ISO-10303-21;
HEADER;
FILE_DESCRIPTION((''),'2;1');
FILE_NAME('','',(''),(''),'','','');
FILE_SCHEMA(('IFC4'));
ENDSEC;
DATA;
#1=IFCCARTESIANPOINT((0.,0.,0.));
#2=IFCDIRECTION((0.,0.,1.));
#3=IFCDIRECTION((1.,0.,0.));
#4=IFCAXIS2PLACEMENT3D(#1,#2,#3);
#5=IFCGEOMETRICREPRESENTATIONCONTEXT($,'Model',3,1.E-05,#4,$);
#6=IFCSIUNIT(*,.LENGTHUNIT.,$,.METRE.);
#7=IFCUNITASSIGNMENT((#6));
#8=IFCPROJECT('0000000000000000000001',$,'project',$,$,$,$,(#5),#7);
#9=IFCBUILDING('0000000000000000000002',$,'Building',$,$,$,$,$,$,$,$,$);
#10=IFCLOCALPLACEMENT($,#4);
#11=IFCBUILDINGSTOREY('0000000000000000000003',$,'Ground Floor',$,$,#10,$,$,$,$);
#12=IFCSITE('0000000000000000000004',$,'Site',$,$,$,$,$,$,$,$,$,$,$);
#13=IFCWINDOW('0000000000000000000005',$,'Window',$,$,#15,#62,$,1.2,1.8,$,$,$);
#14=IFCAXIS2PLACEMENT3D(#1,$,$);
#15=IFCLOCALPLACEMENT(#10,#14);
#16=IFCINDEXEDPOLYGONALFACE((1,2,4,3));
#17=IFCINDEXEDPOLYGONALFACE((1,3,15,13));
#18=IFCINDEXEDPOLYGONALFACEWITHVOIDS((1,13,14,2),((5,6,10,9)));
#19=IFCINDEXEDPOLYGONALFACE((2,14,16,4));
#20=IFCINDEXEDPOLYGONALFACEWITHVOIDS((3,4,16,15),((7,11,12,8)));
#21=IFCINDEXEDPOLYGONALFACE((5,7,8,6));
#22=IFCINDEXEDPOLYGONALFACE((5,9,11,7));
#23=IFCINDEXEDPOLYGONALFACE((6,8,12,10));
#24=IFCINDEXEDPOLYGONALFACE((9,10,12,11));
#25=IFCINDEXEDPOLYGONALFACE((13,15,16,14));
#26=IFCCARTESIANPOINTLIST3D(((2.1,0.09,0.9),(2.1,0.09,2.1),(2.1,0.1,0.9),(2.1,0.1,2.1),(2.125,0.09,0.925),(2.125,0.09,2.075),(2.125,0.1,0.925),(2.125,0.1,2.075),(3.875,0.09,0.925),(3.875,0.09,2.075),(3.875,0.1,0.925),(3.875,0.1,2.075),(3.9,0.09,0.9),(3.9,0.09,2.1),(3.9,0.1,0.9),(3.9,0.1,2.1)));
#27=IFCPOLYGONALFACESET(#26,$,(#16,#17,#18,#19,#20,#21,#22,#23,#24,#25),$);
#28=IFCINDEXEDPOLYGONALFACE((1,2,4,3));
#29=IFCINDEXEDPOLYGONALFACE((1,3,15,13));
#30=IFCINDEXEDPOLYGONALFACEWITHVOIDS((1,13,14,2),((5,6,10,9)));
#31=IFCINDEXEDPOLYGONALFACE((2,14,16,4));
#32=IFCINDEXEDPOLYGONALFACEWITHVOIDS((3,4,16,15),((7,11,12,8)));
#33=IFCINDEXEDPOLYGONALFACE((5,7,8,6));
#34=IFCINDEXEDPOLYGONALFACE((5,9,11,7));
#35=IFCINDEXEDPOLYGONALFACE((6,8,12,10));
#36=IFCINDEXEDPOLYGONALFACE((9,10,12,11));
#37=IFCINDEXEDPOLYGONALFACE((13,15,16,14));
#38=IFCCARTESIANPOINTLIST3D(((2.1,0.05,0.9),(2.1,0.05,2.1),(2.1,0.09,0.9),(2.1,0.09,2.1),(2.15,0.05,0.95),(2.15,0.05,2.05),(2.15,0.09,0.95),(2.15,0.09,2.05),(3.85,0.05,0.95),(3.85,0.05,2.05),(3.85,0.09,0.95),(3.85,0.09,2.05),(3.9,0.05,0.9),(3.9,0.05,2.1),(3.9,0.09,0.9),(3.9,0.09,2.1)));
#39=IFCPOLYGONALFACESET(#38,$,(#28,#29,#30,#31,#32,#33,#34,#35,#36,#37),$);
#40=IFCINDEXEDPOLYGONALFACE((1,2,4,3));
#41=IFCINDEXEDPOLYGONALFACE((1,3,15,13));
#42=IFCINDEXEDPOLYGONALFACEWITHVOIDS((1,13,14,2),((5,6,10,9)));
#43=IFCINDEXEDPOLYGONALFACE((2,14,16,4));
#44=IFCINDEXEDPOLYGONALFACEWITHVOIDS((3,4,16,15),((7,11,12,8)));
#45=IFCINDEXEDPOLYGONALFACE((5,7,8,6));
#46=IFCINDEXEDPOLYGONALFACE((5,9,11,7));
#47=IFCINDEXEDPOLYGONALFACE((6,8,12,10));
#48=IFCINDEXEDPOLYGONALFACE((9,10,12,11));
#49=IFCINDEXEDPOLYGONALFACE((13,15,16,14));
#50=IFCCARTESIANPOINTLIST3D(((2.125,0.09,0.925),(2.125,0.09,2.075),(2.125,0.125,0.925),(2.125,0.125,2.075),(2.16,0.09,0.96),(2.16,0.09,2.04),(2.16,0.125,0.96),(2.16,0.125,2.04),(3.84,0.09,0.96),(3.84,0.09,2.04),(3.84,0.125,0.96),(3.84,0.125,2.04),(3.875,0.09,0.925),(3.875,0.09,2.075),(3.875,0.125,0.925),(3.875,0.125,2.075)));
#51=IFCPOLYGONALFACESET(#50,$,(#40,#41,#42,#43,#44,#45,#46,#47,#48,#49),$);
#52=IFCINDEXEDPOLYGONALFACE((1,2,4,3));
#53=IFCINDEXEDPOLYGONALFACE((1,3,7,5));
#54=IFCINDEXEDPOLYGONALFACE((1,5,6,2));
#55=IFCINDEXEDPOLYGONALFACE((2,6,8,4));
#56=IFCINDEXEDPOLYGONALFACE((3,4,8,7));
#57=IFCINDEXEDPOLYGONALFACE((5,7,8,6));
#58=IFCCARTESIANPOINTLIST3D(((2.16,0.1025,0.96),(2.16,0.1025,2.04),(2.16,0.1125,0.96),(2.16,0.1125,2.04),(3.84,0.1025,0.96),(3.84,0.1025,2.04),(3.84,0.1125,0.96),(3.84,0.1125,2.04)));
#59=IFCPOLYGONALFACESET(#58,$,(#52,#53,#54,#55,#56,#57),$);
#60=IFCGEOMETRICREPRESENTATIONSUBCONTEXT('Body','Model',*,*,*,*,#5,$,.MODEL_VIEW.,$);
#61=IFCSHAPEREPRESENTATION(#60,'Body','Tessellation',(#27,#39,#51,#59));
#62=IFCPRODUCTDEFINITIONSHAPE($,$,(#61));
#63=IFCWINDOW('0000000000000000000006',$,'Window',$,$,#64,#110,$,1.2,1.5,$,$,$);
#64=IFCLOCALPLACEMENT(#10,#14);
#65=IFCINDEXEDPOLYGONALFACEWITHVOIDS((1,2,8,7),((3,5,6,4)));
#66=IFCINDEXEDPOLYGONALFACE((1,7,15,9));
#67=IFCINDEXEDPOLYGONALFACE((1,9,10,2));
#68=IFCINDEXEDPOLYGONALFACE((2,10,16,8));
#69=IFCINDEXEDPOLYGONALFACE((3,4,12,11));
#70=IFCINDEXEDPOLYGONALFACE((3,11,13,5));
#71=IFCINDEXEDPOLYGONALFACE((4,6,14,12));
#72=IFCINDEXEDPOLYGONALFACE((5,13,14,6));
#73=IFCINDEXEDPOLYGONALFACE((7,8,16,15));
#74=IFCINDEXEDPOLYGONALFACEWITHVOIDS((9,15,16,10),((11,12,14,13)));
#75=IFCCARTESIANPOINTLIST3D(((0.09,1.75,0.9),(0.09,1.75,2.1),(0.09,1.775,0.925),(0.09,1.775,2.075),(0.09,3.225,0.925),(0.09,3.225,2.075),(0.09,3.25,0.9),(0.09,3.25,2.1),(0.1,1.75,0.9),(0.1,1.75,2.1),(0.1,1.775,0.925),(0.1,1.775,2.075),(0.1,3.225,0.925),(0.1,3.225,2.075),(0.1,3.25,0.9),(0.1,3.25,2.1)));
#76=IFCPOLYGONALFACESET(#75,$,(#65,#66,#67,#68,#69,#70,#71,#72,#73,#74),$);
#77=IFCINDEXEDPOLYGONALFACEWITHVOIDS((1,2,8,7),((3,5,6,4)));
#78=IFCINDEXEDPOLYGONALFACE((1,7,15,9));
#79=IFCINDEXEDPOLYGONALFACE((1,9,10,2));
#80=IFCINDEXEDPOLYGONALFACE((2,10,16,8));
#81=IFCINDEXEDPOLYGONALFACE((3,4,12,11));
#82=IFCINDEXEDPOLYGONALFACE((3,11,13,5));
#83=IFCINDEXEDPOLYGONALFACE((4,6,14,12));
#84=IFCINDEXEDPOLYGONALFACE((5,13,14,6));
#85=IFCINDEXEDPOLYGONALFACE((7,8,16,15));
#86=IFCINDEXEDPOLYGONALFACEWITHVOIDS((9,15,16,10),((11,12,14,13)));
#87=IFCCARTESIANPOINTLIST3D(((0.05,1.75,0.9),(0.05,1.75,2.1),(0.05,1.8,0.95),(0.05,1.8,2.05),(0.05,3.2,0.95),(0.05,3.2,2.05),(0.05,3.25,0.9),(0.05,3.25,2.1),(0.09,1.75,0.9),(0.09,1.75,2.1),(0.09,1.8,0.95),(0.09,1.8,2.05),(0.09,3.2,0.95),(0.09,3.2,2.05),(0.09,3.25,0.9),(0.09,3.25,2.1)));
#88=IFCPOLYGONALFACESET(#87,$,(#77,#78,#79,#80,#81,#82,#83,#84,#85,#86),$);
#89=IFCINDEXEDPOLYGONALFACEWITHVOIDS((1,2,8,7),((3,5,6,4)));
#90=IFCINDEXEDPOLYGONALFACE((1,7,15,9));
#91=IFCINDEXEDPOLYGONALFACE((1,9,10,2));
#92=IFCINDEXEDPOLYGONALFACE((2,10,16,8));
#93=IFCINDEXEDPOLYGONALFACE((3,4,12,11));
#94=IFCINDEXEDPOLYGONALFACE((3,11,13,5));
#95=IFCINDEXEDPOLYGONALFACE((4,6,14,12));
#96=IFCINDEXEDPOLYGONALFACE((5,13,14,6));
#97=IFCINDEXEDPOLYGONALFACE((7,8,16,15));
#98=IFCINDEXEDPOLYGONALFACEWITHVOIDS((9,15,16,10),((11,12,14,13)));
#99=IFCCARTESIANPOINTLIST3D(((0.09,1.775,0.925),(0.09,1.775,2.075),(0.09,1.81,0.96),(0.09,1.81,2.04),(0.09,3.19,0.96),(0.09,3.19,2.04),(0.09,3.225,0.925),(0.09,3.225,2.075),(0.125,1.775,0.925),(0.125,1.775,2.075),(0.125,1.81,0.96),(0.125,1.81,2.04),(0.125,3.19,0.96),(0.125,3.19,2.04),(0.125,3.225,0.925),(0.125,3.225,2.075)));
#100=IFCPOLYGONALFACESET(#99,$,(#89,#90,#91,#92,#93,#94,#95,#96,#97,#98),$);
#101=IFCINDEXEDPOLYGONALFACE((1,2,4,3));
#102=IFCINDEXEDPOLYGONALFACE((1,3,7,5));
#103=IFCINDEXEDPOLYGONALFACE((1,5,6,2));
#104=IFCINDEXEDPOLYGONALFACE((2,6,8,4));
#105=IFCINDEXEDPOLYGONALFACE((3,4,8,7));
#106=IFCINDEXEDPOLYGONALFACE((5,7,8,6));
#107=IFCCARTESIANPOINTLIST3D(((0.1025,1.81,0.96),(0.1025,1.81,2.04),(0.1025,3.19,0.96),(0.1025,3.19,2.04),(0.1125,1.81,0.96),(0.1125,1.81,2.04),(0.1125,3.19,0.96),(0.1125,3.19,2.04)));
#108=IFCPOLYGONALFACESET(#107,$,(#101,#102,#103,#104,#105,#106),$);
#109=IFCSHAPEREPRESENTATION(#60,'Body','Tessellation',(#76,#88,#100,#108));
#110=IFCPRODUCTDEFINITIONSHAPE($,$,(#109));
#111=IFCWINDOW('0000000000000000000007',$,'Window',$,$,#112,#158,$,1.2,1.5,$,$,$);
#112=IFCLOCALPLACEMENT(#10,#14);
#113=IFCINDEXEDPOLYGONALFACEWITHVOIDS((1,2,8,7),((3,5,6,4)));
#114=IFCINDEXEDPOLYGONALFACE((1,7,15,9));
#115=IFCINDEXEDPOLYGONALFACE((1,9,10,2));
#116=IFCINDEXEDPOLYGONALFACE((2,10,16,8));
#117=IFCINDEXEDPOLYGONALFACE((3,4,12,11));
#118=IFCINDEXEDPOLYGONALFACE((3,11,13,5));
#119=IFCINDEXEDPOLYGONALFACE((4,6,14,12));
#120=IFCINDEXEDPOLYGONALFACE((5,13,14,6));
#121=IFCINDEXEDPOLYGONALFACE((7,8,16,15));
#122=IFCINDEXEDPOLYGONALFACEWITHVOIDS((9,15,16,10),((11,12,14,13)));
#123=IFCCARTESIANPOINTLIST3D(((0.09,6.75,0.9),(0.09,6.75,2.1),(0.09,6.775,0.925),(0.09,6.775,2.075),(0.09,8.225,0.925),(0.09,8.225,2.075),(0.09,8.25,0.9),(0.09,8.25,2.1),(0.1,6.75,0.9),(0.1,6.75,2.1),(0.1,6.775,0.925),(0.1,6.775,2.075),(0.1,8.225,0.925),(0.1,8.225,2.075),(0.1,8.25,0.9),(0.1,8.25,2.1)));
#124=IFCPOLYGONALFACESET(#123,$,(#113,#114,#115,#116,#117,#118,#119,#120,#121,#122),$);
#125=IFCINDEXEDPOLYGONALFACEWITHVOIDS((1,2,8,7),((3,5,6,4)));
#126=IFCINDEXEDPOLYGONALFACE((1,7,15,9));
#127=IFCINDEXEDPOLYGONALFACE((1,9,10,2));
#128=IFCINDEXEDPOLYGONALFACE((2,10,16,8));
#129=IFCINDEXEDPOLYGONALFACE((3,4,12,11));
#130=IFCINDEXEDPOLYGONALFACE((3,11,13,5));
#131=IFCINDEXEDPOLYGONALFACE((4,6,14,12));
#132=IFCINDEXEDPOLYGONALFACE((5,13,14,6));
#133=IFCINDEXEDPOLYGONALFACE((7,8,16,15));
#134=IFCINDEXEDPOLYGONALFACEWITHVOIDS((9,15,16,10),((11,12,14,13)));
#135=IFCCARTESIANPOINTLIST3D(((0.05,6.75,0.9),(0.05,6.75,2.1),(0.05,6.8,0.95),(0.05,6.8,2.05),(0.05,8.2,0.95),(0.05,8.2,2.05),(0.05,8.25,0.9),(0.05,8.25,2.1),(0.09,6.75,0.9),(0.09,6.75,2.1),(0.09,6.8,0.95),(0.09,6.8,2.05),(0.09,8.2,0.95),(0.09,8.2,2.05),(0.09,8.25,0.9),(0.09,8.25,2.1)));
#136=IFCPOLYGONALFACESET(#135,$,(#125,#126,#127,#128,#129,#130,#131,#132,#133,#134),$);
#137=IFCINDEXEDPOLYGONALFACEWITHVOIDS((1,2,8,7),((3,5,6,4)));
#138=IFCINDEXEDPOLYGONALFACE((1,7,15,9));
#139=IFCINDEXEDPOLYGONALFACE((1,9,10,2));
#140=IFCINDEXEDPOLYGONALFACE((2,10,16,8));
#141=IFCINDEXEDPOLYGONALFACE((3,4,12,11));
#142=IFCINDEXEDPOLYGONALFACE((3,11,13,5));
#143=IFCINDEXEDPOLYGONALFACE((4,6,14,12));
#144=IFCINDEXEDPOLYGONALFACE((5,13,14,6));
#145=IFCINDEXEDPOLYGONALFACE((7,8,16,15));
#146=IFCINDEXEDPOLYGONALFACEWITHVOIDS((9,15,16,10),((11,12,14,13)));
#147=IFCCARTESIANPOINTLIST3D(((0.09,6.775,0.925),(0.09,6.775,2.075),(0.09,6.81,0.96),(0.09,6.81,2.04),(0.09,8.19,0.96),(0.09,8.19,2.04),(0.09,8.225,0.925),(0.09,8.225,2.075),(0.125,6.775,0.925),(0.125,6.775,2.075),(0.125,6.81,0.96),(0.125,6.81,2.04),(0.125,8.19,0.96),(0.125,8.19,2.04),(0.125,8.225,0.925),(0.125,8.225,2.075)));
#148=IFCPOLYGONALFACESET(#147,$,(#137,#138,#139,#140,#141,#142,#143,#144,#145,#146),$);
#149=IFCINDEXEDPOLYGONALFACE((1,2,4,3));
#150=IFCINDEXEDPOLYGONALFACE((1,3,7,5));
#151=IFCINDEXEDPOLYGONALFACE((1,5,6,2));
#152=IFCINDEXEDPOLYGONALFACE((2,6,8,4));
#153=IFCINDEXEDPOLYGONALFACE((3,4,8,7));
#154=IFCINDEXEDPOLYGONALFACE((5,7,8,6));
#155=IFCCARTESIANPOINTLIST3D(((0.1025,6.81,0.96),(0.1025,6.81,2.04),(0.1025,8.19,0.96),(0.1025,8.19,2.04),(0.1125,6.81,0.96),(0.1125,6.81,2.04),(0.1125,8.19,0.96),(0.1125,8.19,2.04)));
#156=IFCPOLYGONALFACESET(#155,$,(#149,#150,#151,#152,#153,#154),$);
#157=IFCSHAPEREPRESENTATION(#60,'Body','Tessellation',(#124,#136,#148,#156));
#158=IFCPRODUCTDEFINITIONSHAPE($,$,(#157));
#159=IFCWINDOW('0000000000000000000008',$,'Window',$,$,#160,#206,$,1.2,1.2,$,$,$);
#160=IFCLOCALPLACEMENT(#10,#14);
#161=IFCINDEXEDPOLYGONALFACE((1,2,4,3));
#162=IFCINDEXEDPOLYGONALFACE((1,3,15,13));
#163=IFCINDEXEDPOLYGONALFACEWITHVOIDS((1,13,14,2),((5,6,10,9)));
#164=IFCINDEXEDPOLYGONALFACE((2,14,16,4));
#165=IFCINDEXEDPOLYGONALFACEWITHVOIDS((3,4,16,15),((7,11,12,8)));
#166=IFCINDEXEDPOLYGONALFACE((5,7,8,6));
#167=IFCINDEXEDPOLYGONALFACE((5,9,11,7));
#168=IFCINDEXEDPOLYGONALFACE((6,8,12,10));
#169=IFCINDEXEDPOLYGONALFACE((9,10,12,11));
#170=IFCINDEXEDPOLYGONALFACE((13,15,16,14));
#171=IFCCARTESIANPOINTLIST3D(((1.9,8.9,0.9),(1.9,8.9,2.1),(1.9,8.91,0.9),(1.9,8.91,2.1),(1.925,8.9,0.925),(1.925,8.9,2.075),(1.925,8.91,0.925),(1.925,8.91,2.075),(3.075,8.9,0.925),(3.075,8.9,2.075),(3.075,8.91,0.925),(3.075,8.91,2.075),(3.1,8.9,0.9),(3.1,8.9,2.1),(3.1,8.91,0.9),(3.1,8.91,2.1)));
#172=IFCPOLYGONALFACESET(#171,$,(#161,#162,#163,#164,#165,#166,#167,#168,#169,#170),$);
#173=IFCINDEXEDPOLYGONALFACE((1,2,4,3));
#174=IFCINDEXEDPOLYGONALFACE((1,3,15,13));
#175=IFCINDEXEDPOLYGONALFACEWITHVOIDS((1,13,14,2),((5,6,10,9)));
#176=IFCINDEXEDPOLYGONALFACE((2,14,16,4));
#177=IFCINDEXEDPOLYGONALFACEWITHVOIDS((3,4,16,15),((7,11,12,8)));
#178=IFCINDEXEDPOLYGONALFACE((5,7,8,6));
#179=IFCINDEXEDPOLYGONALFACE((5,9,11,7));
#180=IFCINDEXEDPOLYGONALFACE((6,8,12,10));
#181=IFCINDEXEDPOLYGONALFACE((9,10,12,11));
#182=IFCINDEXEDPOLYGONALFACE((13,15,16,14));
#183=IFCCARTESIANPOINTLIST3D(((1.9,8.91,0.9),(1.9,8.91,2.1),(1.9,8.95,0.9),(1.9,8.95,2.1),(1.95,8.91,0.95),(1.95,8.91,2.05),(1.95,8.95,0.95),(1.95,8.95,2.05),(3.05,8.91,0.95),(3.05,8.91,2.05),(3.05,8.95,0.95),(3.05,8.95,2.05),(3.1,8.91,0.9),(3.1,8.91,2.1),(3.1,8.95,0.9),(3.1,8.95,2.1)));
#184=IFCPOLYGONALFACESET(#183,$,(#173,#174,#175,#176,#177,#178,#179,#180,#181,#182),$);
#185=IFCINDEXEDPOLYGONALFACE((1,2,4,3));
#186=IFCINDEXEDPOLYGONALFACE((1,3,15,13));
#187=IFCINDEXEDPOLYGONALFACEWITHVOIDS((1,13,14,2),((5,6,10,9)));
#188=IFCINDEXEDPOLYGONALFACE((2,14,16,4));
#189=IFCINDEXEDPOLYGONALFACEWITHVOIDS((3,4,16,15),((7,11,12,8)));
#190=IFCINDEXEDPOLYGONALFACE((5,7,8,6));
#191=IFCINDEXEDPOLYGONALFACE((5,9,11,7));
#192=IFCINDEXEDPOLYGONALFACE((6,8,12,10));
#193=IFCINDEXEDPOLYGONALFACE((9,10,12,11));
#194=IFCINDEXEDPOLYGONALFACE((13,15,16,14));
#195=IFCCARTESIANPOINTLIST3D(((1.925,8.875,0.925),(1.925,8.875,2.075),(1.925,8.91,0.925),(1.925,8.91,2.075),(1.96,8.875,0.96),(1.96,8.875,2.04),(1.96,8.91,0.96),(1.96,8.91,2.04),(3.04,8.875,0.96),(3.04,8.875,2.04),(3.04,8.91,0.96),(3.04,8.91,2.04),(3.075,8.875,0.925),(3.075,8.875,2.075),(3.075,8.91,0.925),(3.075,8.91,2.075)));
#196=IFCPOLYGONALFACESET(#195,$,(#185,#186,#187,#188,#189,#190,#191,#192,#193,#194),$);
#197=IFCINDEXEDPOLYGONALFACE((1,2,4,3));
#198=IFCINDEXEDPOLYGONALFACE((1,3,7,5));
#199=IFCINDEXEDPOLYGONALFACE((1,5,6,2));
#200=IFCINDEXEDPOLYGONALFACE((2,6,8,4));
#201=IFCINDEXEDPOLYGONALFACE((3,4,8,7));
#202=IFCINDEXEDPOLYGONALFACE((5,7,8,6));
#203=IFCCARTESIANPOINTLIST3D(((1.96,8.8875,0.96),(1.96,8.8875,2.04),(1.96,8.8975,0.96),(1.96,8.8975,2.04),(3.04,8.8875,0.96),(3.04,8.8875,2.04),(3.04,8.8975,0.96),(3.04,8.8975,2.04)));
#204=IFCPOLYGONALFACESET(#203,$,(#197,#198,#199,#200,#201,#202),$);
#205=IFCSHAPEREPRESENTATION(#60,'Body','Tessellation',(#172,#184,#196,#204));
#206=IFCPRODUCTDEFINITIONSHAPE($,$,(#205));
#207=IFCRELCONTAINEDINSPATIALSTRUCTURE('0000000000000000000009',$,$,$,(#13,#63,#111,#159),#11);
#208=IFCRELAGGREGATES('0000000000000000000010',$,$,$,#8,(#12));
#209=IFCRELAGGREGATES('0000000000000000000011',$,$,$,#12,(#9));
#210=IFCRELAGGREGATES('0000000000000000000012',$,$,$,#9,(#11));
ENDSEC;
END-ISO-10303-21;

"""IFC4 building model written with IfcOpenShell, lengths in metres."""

from ifc_helpers import new_model, si_unit, frame, origin_with_axes, place, context, subcontext, project, spatial, line, indexed_curve, outline, extrude, element, save


model = new_model("IFC4")

# Units and contexts
model_context = context("Model", 3, precision=1e-05, world=origin_with_axes())
body_context = subcontext(model_context, "Body", "Model", "MODEL_VIEW")
ifc_project = project(units=[si_unit("LENGTHUNIT", "METRE")], contexts=[model_context])

# Site, building, storey
site = spatial("IfcSite", under=ifc_project, Name="Site")
building = spatial("IfcBuilding", under=site, Name="Building")
storey_placement = place(None, origin_with_axes())
storey = spatial("IfcBuildingStorey", under=building, at=storey_placement, Name="Ground Floor")

# Windows
window_1_placement = place(storey_placement, frame((2.1, 0.0, 0.9), z_axis=(0.0, 0.0, 1.0), x_axis=(1.0, 0.0, 0.0)))
element("IfcWindow", 1, at=window_1_placement, inside=storey, Name="Window", OverallHeight=1.2, OverallWidth=1.8, context=body_context, shape_type="SweptSolid", body=[
    extrude(outline(indexed_curve([(0.0, 0.0), (1.8, 0.0), (1.8, 1.2), (0.0, 1.2)], segments=[line(1, 2, 3, 4, 1)]), holes=[indexed_curve([(0.025, 0.025), (1.775, 0.025), (1.775, 1.175), (0.025, 1.175)], segments=[line(1, 2, 3, 4, 1)])]), frame((0.0, 0.09, 0.0), z_axis=(0.0, -1.0, 0.0), x_axis=(1.0, 0.0, 0.0)), (0.0, 0.0, -1.0), 0.01),
    extrude(outline(indexed_curve([(0.0, 0.0), (1.8, 0.0), (1.8, 1.2), (0.0, 1.2)], segments=[line(1, 2, 3, 4, 1)]), holes=[indexed_curve([(0.05, 0.05), (1.75, 0.05), (1.75, 1.15), (0.05, 1.15)], segments=[line(1, 2, 3, 4, 1)])]), frame((0.0, 0.05, 0.0), z_axis=(0.0, -1.0, 0.0), x_axis=(1.0, 0.0, 0.0)), (0.0, 0.0, -1.0), 0.04),
    extrude(outline(indexed_curve([(0.0, 0.0), (1.75, 0.0), (1.75, 1.15), (0.0, 1.15)], segments=[line(1, 2, 3, 4, 1)]), holes=[indexed_curve([(0.035, 0.035), (1.715, 0.035), (1.715, 1.115), (0.035, 1.115)], segments=[line(1, 2, 3, 4, 1)])]), frame((0.025, 0.09, 0.025), z_axis=(0.0, -1.0, 0.0), x_axis=(1.0, 0.0, 0.0)), (0.0, 0.0, -1.0), 0.035),
    extrude(outline(indexed_curve([(0.035, 0.035), (1.715, 0.035), (1.715, 1.115), (0.035, 1.115)], segments=[line(1, 2, 3, 4, 1)])), frame((0.025, 0.1025, 0.025), z_axis=(0.0, -1.0, 0.0), x_axis=(1.0, 0.0, 0.0)), (0.0, 0.0, -1.0), 0.01),
])
for number, where, z_axis, x_axis, name in (
    (2, (0.0, 3.25, 0.9), (0.0, 0.0, 1.0), (0.0, -1.0, 0.0), "Window"),
    (3, (0.0, 8.25, 0.9), (0.0, 0.0, 1.0), (0.0, -1.0, 0.0), "Window"),
):
    element("IfcWindow", number, at=place(storey_placement, frame(where, z_axis=z_axis, x_axis=x_axis)), inside=storey, Name=name, OverallHeight=1.2, OverallWidth=1.5, context=body_context, shape_type="SweptSolid", body=[
        extrude(outline(indexed_curve([(0.0, 0.0), (1.5, 0.0), (1.5, 1.2), (0.0, 1.2)], segments=[line(1, 2, 3, 4, 1)]), holes=[indexed_curve([(0.025, 0.025), (1.475, 0.025), (1.475, 1.175), (0.025, 1.175)], segments=[line(1, 2, 3, 4, 1)])]), frame((0.0, 0.09, 0.0), z_axis=(0.0, -1.0, 0.0), x_axis=(1.0, 0.0, 0.0)), (0.0, 0.0, -1.0), 0.01),
        extrude(outline(indexed_curve([(0.0, 0.0), (1.5, 0.0), (1.5, 1.2), (0.0, 1.2)], segments=[line(1, 2, 3, 4, 1)]), holes=[indexed_curve([(0.05, 0.05), (1.45, 0.05), (1.45, 1.15), (0.05, 1.15)], segments=[line(1, 2, 3, 4, 1)])]), frame((0.0, 0.05, 0.0), z_axis=(0.0, -1.0, 0.0), x_axis=(1.0, 0.0, 0.0)), (0.0, 0.0, -1.0), 0.04),
        extrude(outline(indexed_curve([(0.0, 0.0), (1.45, 0.0), (1.45, 1.15), (0.0, 1.15)], segments=[line(1, 2, 3, 4, 1)]), holes=[indexed_curve([(0.035, 0.035), (1.415, 0.035), (1.415, 1.115), (0.035, 1.115)], segments=[line(1, 2, 3, 4, 1)])]), frame((0.025, 0.09, 0.025), z_axis=(0.0, -1.0, 0.0), x_axis=(1.0, 0.0, 0.0)), (0.0, 0.0, -1.0), 0.035),
        extrude(outline(indexed_curve([(0.035, 0.035), (1.415, 0.035), (1.415, 1.115), (0.035, 1.115)], segments=[line(1, 2, 3, 4, 1)])), frame((0.025, 0.1025, 0.025), z_axis=(0.0, -1.0, 0.0), x_axis=(1.0, 0.0, 0.0)), (0.0, 0.0, -1.0), 0.01),
    ])
window_2_placement = place(storey_placement, frame((3.1, 9.0, 0.9), z_axis=(0.0, 0.0, 1.0), x_axis=(-1.0, 0.0, 0.0)))
element("IfcWindow", 4, at=window_2_placement, inside=storey, Name="Window", OverallHeight=1.2, OverallWidth=1.2, context=body_context, shape_type="SweptSolid", body=[
    extrude(outline(indexed_curve([(0.0, 0.0), (1.2, 0.0), (1.2, 1.2), (0.0, 1.2)], segments=[line(1, 2, 3, 4, 1)]), holes=[indexed_curve([(0.025, 0.025), (1.175, 0.025), (1.175, 1.175), (0.025, 1.175)], segments=[line(1, 2, 3, 4, 1)])]), frame((0.0, 0.09, 0.0), z_axis=(0.0, -1.0, 0.0), x_axis=(1.0, 0.0, 0.0)), (0.0, 0.0, -1.0), 0.01),
    extrude(outline(indexed_curve([(0.0, 0.0), (1.2, 0.0), (1.2, 1.2), (0.0, 1.2)], segments=[line(1, 2, 3, 4, 1)]), holes=[indexed_curve([(0.05, 0.05), (1.15, 0.05), (1.15, 1.15), (0.05, 1.15)], segments=[line(1, 2, 3, 4, 1)])]), frame((0.0, 0.05, 0.0), z_axis=(0.0, -1.0, 0.0), x_axis=(1.0, 0.0, 0.0)), (0.0, 0.0, -1.0), 0.04),
    extrude(outline(indexed_curve([(0.0, 0.0), (1.15, 0.0), (1.15, 1.15), (0.0, 1.15)], segments=[line(1, 2, 3, 4, 1)]), holes=[indexed_curve([(0.035, 0.035), (1.115, 0.035), (1.115, 1.115), (0.035, 1.115)], segments=[line(1, 2, 3, 4, 1)])]), frame((0.025, 0.09, 0.025), z_axis=(0.0, -1.0, 0.0), x_axis=(1.0, 0.0, 0.0)), (0.0, 0.0, -1.0), 0.035),
    extrude(outline(indexed_curve([(0.035, 0.035), (1.115, 0.035), (1.115, 1.115), (0.035, 1.115)], segments=[line(1, 2, 3, 4, 1)])), frame((0.025, 0.1025, 0.025), z_axis=(0.0, -1.0, 0.0), x_axis=(1.0, 0.0, 0.0)), (0.0, 0.0, -1.0), 0.01),
])

save(model, "model.ifc")
